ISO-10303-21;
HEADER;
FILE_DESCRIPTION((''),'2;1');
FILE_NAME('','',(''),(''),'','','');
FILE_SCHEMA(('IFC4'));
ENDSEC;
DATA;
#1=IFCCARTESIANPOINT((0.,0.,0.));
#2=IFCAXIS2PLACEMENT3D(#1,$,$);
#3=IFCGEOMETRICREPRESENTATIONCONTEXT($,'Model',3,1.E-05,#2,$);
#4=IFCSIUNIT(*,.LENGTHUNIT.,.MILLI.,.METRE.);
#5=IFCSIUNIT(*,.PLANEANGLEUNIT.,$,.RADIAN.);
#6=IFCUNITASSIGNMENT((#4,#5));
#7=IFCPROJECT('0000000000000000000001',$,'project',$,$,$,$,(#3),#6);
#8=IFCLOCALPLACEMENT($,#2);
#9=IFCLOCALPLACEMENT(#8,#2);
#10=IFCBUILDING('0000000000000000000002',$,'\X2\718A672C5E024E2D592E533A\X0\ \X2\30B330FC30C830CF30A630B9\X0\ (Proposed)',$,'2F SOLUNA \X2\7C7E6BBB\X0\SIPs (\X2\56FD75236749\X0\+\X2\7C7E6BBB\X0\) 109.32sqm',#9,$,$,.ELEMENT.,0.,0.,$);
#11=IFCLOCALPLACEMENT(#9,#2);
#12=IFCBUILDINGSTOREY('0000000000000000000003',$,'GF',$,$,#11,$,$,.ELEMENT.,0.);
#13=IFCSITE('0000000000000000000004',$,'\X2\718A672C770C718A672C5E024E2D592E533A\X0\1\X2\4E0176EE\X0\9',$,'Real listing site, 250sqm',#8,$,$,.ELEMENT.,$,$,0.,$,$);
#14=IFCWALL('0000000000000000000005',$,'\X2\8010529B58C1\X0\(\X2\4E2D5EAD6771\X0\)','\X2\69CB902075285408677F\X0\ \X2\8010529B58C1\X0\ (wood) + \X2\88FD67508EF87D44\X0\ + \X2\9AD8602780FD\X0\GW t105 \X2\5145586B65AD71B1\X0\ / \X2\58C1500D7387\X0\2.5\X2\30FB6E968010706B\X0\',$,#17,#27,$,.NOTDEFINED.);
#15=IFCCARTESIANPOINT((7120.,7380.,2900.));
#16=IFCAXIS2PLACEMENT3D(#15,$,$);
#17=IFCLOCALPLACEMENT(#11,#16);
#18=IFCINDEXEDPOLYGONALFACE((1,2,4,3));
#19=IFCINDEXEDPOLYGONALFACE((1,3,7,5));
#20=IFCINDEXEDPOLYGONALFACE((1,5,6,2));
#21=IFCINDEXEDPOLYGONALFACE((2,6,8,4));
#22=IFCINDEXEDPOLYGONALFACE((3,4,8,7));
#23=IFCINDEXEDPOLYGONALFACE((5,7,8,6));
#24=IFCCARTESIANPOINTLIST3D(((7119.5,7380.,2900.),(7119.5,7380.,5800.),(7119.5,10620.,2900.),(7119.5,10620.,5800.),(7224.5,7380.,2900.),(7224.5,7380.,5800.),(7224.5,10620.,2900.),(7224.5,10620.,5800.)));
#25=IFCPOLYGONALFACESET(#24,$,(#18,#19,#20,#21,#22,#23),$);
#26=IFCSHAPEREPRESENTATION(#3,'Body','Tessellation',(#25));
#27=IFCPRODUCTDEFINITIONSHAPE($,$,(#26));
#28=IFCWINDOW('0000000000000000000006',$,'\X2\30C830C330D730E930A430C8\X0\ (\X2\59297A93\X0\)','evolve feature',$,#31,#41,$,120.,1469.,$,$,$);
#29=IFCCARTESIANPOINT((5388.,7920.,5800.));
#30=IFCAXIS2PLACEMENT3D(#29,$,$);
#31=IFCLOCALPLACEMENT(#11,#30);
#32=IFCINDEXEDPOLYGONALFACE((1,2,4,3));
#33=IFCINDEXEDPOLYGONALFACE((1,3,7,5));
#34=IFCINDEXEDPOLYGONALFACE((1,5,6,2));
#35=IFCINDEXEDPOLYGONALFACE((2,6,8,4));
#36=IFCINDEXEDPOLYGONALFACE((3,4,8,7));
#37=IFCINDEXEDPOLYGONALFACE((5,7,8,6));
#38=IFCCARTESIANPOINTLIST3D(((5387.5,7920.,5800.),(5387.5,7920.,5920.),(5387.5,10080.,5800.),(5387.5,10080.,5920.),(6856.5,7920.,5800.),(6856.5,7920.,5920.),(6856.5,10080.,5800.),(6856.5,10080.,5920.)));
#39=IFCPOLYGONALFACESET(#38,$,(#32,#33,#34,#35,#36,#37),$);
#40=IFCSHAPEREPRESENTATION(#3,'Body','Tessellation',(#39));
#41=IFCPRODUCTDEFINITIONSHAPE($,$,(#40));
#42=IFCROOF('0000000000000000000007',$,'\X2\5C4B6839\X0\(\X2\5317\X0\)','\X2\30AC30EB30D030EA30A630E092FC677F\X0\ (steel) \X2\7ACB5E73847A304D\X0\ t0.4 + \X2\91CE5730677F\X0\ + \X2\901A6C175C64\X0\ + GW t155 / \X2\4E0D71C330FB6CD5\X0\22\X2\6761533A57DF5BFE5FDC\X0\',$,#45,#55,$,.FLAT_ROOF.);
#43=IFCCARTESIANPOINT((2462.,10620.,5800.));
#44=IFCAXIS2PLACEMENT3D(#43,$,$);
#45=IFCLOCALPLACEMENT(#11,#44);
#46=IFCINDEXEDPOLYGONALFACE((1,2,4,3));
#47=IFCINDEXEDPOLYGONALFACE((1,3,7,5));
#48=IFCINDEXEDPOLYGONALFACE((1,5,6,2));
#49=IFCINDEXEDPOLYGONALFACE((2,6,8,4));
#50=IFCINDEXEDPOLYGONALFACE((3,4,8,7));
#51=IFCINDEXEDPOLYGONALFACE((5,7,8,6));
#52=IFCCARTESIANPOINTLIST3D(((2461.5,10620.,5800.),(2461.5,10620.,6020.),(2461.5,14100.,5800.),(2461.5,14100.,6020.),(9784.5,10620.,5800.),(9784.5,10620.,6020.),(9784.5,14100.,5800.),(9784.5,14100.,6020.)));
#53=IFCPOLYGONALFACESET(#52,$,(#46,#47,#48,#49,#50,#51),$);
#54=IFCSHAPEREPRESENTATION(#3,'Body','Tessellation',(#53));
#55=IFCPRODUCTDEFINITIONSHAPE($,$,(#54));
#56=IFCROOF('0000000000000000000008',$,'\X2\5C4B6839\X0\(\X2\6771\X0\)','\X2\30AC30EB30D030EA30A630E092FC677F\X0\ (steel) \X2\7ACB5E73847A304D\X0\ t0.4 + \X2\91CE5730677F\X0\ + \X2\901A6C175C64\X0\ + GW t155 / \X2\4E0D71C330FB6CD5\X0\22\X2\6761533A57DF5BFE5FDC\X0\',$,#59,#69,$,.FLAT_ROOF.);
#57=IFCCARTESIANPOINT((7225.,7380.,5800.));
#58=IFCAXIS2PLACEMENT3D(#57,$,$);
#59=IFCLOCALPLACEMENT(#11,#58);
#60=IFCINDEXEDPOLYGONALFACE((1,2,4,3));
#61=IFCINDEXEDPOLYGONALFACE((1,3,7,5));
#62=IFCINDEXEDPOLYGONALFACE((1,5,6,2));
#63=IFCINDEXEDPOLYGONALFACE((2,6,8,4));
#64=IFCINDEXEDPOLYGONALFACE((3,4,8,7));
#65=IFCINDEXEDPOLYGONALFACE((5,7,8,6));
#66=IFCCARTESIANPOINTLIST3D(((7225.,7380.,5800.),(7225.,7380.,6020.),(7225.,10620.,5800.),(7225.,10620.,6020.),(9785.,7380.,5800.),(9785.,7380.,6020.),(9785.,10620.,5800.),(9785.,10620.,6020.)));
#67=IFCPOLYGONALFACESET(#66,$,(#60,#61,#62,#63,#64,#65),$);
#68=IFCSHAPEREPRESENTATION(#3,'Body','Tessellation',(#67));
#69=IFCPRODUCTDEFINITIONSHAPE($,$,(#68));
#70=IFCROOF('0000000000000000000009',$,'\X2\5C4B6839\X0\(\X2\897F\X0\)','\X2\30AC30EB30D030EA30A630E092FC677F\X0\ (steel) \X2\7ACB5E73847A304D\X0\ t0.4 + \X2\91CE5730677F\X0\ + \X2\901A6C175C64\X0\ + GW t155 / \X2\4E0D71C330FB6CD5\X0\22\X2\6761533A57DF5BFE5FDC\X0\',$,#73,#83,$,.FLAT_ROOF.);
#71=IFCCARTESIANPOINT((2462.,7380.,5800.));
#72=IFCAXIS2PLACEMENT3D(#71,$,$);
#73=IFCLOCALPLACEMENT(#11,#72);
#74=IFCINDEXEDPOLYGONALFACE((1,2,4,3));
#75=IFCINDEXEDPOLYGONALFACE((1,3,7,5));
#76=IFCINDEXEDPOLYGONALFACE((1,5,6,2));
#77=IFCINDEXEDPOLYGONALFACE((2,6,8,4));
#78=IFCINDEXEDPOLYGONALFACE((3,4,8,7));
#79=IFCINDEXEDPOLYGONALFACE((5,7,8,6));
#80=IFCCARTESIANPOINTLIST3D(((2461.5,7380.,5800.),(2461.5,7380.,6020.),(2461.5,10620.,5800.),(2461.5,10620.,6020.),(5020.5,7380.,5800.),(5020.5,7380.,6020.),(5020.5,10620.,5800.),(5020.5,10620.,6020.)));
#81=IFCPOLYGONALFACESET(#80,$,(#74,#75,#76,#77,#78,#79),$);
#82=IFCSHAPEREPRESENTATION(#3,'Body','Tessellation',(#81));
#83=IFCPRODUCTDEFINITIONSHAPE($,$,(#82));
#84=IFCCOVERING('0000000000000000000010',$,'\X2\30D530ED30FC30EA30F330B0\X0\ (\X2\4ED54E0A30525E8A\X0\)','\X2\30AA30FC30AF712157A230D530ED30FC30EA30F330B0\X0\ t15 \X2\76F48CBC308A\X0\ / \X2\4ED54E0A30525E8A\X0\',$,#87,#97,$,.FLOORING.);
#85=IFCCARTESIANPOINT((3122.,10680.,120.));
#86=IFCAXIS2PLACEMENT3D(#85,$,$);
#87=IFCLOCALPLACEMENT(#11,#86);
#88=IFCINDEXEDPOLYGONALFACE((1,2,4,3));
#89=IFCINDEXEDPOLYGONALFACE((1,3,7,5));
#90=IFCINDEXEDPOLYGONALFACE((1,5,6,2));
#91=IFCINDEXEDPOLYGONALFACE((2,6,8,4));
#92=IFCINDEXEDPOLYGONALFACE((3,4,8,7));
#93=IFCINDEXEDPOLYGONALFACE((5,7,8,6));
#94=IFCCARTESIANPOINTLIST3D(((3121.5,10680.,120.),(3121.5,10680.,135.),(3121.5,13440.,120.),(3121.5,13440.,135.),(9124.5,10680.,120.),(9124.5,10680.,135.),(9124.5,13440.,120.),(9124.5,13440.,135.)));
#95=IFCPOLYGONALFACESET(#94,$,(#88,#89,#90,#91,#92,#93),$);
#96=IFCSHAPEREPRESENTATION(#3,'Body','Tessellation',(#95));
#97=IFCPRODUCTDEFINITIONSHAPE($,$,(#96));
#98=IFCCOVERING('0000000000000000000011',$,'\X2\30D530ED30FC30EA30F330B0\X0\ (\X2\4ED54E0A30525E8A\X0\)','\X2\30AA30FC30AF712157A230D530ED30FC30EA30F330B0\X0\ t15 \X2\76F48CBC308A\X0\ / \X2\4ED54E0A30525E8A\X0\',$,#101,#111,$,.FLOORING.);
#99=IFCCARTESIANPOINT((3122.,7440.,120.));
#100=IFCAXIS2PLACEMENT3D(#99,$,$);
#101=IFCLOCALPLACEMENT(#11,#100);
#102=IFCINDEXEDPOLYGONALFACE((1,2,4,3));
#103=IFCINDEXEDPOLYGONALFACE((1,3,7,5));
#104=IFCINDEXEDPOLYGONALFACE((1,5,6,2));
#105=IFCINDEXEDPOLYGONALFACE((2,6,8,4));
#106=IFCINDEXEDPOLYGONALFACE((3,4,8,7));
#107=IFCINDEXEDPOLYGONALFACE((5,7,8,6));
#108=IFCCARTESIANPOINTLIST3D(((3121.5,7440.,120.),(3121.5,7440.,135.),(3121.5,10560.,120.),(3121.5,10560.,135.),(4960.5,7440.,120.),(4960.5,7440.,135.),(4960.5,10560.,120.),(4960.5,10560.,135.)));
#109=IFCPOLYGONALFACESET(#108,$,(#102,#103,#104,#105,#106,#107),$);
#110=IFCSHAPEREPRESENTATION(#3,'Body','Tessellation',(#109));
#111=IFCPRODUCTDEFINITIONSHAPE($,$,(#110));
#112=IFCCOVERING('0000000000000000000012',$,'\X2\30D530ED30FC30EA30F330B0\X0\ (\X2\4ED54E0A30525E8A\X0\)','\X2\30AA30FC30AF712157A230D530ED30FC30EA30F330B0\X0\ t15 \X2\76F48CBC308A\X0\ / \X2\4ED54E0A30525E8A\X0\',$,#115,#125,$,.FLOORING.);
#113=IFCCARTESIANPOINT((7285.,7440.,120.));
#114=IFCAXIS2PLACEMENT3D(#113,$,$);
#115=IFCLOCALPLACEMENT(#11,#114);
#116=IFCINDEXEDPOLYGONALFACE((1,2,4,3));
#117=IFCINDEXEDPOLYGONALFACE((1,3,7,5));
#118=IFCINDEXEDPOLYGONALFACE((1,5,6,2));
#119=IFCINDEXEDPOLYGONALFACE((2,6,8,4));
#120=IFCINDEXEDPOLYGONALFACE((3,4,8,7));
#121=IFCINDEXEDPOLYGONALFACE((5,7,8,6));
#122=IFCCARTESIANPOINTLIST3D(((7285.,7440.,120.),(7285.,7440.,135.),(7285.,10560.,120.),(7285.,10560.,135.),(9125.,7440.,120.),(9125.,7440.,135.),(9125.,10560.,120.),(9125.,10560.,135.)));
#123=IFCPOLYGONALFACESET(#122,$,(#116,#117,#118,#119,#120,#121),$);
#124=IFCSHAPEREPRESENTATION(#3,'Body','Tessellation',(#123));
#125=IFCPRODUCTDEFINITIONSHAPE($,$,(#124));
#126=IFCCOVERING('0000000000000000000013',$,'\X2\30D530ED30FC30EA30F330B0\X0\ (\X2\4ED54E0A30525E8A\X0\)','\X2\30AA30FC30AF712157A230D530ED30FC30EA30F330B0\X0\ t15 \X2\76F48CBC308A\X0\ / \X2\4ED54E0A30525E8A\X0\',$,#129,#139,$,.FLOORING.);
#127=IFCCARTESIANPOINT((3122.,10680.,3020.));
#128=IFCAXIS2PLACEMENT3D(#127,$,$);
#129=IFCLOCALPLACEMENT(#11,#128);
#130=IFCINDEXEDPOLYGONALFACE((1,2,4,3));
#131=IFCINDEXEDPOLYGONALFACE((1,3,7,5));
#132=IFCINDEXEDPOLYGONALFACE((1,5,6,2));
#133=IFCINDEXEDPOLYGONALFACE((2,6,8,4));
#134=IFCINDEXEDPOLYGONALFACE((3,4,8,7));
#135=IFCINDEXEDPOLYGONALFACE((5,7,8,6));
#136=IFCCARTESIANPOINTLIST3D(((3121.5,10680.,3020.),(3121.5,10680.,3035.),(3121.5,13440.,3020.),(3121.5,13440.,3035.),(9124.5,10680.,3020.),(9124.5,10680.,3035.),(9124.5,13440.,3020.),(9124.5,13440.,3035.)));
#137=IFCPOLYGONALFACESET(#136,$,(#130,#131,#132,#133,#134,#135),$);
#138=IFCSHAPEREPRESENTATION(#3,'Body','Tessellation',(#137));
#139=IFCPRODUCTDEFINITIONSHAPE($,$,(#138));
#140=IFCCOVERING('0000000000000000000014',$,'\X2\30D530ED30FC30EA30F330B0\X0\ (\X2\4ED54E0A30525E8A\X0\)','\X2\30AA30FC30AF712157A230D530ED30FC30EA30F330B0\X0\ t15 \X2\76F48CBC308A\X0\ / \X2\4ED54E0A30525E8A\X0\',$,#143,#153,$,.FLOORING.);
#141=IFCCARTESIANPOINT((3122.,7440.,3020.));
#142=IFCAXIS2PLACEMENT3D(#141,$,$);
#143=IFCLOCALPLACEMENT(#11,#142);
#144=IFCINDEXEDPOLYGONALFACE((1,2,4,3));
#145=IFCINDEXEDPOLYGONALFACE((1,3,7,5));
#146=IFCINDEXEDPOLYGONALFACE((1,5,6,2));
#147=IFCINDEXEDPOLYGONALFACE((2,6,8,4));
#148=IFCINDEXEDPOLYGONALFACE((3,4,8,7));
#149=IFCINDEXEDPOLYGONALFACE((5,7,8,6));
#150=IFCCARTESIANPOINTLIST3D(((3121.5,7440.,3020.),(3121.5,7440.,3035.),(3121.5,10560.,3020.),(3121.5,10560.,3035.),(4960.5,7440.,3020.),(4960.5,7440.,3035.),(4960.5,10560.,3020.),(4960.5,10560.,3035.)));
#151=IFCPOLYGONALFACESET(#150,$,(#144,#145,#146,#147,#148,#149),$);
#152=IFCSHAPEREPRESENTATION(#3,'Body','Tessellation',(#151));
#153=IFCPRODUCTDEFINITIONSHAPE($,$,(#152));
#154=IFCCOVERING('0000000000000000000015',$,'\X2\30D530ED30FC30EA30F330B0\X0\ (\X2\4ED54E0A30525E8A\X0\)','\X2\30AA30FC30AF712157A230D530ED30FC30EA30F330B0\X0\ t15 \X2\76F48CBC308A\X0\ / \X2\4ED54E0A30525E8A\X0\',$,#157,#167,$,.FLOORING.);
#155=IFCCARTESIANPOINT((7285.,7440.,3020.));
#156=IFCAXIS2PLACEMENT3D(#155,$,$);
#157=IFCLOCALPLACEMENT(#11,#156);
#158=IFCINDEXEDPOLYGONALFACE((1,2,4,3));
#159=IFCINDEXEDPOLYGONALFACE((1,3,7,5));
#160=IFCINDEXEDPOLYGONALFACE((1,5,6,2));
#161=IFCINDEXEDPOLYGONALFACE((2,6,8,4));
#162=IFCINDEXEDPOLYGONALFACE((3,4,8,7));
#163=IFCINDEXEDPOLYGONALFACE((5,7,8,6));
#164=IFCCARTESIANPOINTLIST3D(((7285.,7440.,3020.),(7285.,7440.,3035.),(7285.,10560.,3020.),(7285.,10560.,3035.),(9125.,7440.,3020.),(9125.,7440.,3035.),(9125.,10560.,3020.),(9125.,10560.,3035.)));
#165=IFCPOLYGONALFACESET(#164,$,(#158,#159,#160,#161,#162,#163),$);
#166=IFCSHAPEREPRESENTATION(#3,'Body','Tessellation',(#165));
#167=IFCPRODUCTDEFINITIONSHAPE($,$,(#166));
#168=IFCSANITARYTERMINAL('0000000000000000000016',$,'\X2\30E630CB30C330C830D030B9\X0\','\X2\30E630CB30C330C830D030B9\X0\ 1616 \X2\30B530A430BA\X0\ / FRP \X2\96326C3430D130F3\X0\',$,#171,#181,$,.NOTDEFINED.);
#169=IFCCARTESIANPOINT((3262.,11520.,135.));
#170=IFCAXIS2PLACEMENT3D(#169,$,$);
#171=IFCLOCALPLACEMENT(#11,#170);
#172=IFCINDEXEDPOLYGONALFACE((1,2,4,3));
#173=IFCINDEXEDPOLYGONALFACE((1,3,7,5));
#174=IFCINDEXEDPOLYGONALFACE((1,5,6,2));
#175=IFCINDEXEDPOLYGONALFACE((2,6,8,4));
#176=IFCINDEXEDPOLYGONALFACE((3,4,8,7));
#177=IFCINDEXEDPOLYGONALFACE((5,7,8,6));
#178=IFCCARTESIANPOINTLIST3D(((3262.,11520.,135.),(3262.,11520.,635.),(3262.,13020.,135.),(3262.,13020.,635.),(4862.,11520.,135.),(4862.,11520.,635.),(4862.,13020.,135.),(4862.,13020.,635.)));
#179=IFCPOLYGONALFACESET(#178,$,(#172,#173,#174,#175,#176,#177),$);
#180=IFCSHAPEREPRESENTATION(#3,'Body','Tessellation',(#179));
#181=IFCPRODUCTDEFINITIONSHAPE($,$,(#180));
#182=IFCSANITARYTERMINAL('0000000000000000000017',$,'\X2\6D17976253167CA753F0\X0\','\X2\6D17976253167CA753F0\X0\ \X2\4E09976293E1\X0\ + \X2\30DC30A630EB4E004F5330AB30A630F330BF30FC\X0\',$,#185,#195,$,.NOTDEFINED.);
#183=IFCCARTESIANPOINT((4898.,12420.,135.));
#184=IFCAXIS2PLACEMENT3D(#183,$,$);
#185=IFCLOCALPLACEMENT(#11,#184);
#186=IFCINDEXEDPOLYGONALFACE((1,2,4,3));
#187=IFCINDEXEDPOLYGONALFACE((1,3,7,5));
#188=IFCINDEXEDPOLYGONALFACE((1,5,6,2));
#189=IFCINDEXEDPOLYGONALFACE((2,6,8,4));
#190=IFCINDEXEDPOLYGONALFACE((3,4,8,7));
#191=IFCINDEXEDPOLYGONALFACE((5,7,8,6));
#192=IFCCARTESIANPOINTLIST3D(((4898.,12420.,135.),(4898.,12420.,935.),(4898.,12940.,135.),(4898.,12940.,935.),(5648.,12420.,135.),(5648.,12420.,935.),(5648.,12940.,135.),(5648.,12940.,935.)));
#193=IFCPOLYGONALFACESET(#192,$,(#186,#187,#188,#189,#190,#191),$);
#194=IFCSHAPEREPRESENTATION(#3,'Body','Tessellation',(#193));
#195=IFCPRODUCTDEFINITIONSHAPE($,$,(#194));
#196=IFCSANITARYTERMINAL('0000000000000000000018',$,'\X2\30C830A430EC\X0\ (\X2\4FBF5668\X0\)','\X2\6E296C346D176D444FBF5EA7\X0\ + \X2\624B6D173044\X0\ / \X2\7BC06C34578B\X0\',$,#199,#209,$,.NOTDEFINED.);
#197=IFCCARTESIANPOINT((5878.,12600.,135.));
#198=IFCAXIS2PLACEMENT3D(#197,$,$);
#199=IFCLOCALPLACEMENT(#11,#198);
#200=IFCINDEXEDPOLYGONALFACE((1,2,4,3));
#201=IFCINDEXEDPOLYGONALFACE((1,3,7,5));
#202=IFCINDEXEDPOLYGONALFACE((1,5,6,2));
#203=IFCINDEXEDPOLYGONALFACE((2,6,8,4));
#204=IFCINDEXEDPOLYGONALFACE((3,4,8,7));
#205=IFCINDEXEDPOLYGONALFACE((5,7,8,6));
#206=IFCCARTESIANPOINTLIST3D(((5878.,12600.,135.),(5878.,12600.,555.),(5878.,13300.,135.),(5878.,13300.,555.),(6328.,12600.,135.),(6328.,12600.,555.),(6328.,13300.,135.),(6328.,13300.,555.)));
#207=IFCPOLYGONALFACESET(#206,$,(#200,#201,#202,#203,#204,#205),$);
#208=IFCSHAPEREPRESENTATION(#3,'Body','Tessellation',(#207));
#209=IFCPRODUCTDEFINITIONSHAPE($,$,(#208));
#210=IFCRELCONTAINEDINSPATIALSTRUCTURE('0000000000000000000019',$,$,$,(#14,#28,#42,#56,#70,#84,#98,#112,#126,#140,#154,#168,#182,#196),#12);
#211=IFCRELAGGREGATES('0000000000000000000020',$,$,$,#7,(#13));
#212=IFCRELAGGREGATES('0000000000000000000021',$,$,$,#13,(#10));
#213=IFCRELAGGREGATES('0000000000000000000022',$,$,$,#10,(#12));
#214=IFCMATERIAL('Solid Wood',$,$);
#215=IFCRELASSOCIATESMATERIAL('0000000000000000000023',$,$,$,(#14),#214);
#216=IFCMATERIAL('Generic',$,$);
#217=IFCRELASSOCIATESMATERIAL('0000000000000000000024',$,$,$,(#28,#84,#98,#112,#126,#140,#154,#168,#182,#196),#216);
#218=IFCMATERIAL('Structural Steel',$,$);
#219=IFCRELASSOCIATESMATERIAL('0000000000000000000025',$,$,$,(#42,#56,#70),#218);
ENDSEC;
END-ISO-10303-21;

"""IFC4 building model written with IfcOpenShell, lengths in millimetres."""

from ifc_helpers import new_model, si_unit, frame, frame_2d, origin, place, context, project, spatial, rectangle, extrude, material, element, save


model = new_model("IFC4")

# Units and contexts
model_context = context("Model", 3, precision=1e-05, world=origin())
ifc_project = project(units=[si_unit("LENGTHUNIT", "METRE", prefix="MILLI"), si_unit("PLANEANGLEUNIT", "RADIAN")], contexts=[model_context])

# Site, building, storey
site_placement = place(None, origin())
site = spatial("IfcSite", under=ifc_project, at=site_placement, Name="熊本県熊本市中央区1丁目9", ObjectType="Real listing site, 250sqm", CompositionType="ELEMENT", RefElevation=0.0)
building_placement = place(site_placement, origin())
building = spatial("IfcBuilding", under=site, at=building_placement, Name="熊本市中央区 コートハウス (Proposed)", ObjectType="2F SOLUNA 籾殻SIPs (国産杉+籾殻) 109.32sqm", CompositionType="ELEMENT", ElevationOfRefHeight=0.0, ElevationOfTerrain=0.0)
storey_placement = place(building_placement, origin())
storey = spatial("IfcBuildingStorey", under=building, at=storey_placement, Name="GF", CompositionType="ELEMENT", Elevation=0.0)

# Shared definitions
ifc_material_1 = material(Name="Solid Wood")

# Wall
wall_1_placement = place(storey_placement, frame((7120.0, 7380.0, 2900.0)))
element("IfcWall", 1, at=wall_1_placement, inside=storey, material=ifc_material_1, Name="耐力壁(中庭東)", Description="構造用合板 耐力壁 (wood) + 製材軸組 + 高性能GW t105 充填断熱 / 壁倍率2.5・準耐火", PredefinedType="NOTDEFINED", context=model_context, shape_type="SweptSolid", body=[
    extrude(rectangle(XDim=105.0, YDim=3240.0, at=frame_2d((52.0, 1620.0))), frame((7120.0, 7380.0, 2900.0)), (0.0, 0.0, 1.0), 2900.0),
])

# Window
ifc_material_2 = material(Name="Generic")
window_1_placement = place(storey_placement, frame((5388.0, 7920.0, 5800.0)))
element("IfcWindow", 2, at=window_1_placement, inside=storey, material=ifc_material_2, Name="トップライト (天窓)", Description="evolve feature", OverallHeight=120.0, OverallWidth=1469.0, context=model_context, shape_type="SweptSolid", body=[
    extrude(rectangle(XDim=1469.0, YDim=2160.0, at=frame_2d((734.0, 1080.0))), frame((5388.0, 7920.0, 5800.0)), (0.0, 0.0, 1.0), 120.0),
])

# Roofs
ifc_material_3 = material(Name="Structural Steel")
roof_1_placement = place(storey_placement, frame((2462.0, 10620.0, 5800.0)))
element("IfcRoof", 3, at=roof_1_placement, inside=storey, material=ifc_material_3, Name="屋根(北)", Description="ガルバリウム鋼板 (steel) 立平葺き t0.4 + 野地板 + 通気層 + GW t155 / 不燃・法22条区域対応", PredefinedType="FLAT_ROOF", context=model_context, shape_type="SweptSolid", body=[
    extrude(rectangle(XDim=7323.0, YDim=3480.0, at=frame_2d((3661.0, 1740.0))), frame((2462.0, 10620.0, 5800.0)), (0.0, 0.0, 1.0), 220.0),
])
roof_2_placement = place(storey_placement, frame((7225.0, 7380.0, 5800.0)))
element("IfcRoof", 4, at=roof_2_placement, inside=storey, material=ifc_material_3, Name="屋根(東)", Description="ガルバリウム鋼板 (steel) 立平葺き t0.4 + 野地板 + 通気層 + GW t155 / 不燃・法22条区域対応", PredefinedType="FLAT_ROOF", context=model_context, shape_type="SweptSolid", body=[
    extrude(rectangle(XDim=2560.0, YDim=3240.0, at=frame_2d((1280.0, 1620.0))), frame((7225.0, 7380.0, 5800.0)), (0.0, 0.0, 1.0), 220.0),
])
roof_3_placement = place(storey_placement, frame((2462.0, 7380.0, 5800.0)))
element("IfcRoof", 5, at=roof_3_placement, inside=storey, material=ifc_material_3, Name="屋根(西)", Description="ガルバリウム鋼板 (steel) 立平葺き t0.4 + 野地板 + 通気層 + GW t155 / 不燃・法22条区域対応", PredefinedType="FLAT_ROOF", context=model_context, shape_type="SweptSolid", body=[
    extrude(rectangle(XDim=2559.0, YDim=3240.0, at=frame_2d((1279.0, 1620.0))), frame((2462.0, 7380.0, 5800.0)), (0.0, 0.0, 1.0), 220.0),
])

# Coverings
covering_1_placement = place(storey_placement, frame((3122.0, 10680.0, 120.0)))
element("IfcCovering", 6, at=covering_1_placement, inside=storey, material=ifc_material_2, Name="フローリング (仕上げ床)", Description="オーク無垢フローリング t15 直貼り / 仕上げ床", PredefinedType="FLOORING", context=model_context, shape_type="SweptSolid", body=[
    extrude(rectangle(XDim=6003.0, YDim=2760.0, at=frame_2d((3001.0, 1380.0))), frame((3122.0, 10680.0, 120.0)), (0.0, 0.0, 1.0), 15.0),
])
covering_2_placement = place(storey_placement, frame((3122.0, 7440.0, 120.0)))
element("IfcCovering", 7, at=covering_2_placement, inside=storey, material=ifc_material_2, Name="フローリング (仕上げ床)", Description="オーク無垢フローリング t15 直貼り / 仕上げ床", PredefinedType="FLOORING", context=model_context, shape_type="SweptSolid", body=[
    extrude(rectangle(XDim=1839.0, YDim=3120.0, at=frame_2d((919.0, 1560.0))), frame((3122.0, 7440.0, 120.0)), (0.0, 0.0, 1.0), 15.0),
])
covering_3_placement = place(storey_placement, frame((7285.0, 7440.0, 120.0)))
element("IfcCovering", 8, at=covering_3_placement, inside=storey, material=ifc_material_2, Name="フローリング (仕上げ床)", Description="オーク無垢フローリング t15 直貼り / 仕上げ床", PredefinedType="FLOORING", context=model_context, shape_type="SweptSolid", body=[
    extrude(rectangle(XDim=1840.0, YDim=3120.0, at=frame_2d((920.0, 1560.0))), frame((7285.0, 7440.0, 120.0)), (0.0, 0.0, 1.0), 15.0),
])
covering_4_placement = place(storey_placement, frame((3122.0, 10680.0, 3020.0)))
element("IfcCovering", 9, at=covering_4_placement, inside=storey, material=ifc_material_2, Name="フローリング (仕上げ床)", Description="オーク無垢フローリング t15 直貼り / 仕上げ床", PredefinedType="FLOORING", context=model_context, shape_type="SweptSolid", body=[
    extrude(rectangle(XDim=6003.0, YDim=2760.0, at=frame_2d((3001.0, 1380.0))), frame((3122.0, 10680.0, 3020.0)), (0.0, 0.0, 1.0), 15.0),
])
covering_5_placement = place(storey_placement, frame((3122.0, 7440.0, 3020.0)))
element("IfcCovering", 10, at=covering_5_placement, inside=storey, material=ifc_material_2, Name="フローリング (仕上げ床)", Description="オーク無垢フローリング t15 直貼り / 仕上げ床", PredefinedType="FLOORING", context=model_context, shape_type="SweptSolid", body=[
    extrude(rectangle(XDim=1839.0, YDim=3120.0, at=frame_2d((919.0, 1560.0))), frame((3122.0, 7440.0, 3020.0)), (0.0, 0.0, 1.0), 15.0),
])
covering_6_placement = place(storey_placement, frame((7285.0, 7440.0, 3020.0)))
element("IfcCovering", 11, at=covering_6_placement, inside=storey, material=ifc_material_2, Name="フローリング (仕上げ床)", Description="オーク無垢フローリング t15 直貼り / 仕上げ床", PredefinedType="FLOORING", context=model_context, shape_type="SweptSolid", body=[
    extrude(rectangle(XDim=1840.0, YDim=3120.0, at=frame_2d((920.0, 1560.0))), frame((7285.0, 7440.0, 3020.0)), (0.0, 0.0, 1.0), 15.0),
])

# Sanitary terminals
sanitary_terminal_1_placement = place(storey_placement, frame((3262.0, 11520.0, 135.0)))
element("IfcSanitaryTerminal", 12, at=sanitary_terminal_1_placement, inside=storey, material=ifc_material_2, Name="ユニットバス", Description="ユニットバス 1616 サイズ / FRP 防水パン", PredefinedType="NOTDEFINED", context=model_context, shape_type="SweptSolid", body=[
    extrude(rectangle(XDim=1600.0, YDim=1500.0, at=frame_2d((800.0, 750.0))), frame((3262.0, 11520.0, 135.0)), (0.0, 0.0, 1.0), 500.0),
])
sanitary_terminal_2_placement = place(storey_placement, frame((4898.0, 12420.0, 135.0)))
element("IfcSanitaryTerminal", 13, at=sanitary_terminal_2_placement, inside=storey, material=ifc_material_2, Name="洗面化粧台", Description="洗面化粧台 三面鏡 + ボウル一体カウンター", PredefinedType="NOTDEFINED", context=model_context, shape_type="SweptSolid", body=[
    extrude(rectangle(XDim=750.0, YDim=520.0, at=frame_2d((375.0, 260.0))), frame((4898.0, 12420.0, 135.0)), (0.0, 0.0, 1.0), 800.0),
])
sanitary_terminal_3_placement = place(storey_placement, frame((5878.0, 12600.0, 135.0)))
element("IfcSanitaryTerminal", 14, at=sanitary_terminal_3_placement, inside=storey, material=ifc_material_2, Name="トイレ (便器)", Description="温水洗浄便座 + 手洗い / 節水型", PredefinedType="NOTDEFINED", context=model_context, shape_type="SweptSolid", body=[
    extrude(rectangle(XDim=450.0, YDim=700.0, at=frame_2d((225.0, 350.0))), frame((5878.0, 12600.0, 135.0)), (0.0, 0.0, 1.0), 420.0),
])

save(model, "model.ifc")
